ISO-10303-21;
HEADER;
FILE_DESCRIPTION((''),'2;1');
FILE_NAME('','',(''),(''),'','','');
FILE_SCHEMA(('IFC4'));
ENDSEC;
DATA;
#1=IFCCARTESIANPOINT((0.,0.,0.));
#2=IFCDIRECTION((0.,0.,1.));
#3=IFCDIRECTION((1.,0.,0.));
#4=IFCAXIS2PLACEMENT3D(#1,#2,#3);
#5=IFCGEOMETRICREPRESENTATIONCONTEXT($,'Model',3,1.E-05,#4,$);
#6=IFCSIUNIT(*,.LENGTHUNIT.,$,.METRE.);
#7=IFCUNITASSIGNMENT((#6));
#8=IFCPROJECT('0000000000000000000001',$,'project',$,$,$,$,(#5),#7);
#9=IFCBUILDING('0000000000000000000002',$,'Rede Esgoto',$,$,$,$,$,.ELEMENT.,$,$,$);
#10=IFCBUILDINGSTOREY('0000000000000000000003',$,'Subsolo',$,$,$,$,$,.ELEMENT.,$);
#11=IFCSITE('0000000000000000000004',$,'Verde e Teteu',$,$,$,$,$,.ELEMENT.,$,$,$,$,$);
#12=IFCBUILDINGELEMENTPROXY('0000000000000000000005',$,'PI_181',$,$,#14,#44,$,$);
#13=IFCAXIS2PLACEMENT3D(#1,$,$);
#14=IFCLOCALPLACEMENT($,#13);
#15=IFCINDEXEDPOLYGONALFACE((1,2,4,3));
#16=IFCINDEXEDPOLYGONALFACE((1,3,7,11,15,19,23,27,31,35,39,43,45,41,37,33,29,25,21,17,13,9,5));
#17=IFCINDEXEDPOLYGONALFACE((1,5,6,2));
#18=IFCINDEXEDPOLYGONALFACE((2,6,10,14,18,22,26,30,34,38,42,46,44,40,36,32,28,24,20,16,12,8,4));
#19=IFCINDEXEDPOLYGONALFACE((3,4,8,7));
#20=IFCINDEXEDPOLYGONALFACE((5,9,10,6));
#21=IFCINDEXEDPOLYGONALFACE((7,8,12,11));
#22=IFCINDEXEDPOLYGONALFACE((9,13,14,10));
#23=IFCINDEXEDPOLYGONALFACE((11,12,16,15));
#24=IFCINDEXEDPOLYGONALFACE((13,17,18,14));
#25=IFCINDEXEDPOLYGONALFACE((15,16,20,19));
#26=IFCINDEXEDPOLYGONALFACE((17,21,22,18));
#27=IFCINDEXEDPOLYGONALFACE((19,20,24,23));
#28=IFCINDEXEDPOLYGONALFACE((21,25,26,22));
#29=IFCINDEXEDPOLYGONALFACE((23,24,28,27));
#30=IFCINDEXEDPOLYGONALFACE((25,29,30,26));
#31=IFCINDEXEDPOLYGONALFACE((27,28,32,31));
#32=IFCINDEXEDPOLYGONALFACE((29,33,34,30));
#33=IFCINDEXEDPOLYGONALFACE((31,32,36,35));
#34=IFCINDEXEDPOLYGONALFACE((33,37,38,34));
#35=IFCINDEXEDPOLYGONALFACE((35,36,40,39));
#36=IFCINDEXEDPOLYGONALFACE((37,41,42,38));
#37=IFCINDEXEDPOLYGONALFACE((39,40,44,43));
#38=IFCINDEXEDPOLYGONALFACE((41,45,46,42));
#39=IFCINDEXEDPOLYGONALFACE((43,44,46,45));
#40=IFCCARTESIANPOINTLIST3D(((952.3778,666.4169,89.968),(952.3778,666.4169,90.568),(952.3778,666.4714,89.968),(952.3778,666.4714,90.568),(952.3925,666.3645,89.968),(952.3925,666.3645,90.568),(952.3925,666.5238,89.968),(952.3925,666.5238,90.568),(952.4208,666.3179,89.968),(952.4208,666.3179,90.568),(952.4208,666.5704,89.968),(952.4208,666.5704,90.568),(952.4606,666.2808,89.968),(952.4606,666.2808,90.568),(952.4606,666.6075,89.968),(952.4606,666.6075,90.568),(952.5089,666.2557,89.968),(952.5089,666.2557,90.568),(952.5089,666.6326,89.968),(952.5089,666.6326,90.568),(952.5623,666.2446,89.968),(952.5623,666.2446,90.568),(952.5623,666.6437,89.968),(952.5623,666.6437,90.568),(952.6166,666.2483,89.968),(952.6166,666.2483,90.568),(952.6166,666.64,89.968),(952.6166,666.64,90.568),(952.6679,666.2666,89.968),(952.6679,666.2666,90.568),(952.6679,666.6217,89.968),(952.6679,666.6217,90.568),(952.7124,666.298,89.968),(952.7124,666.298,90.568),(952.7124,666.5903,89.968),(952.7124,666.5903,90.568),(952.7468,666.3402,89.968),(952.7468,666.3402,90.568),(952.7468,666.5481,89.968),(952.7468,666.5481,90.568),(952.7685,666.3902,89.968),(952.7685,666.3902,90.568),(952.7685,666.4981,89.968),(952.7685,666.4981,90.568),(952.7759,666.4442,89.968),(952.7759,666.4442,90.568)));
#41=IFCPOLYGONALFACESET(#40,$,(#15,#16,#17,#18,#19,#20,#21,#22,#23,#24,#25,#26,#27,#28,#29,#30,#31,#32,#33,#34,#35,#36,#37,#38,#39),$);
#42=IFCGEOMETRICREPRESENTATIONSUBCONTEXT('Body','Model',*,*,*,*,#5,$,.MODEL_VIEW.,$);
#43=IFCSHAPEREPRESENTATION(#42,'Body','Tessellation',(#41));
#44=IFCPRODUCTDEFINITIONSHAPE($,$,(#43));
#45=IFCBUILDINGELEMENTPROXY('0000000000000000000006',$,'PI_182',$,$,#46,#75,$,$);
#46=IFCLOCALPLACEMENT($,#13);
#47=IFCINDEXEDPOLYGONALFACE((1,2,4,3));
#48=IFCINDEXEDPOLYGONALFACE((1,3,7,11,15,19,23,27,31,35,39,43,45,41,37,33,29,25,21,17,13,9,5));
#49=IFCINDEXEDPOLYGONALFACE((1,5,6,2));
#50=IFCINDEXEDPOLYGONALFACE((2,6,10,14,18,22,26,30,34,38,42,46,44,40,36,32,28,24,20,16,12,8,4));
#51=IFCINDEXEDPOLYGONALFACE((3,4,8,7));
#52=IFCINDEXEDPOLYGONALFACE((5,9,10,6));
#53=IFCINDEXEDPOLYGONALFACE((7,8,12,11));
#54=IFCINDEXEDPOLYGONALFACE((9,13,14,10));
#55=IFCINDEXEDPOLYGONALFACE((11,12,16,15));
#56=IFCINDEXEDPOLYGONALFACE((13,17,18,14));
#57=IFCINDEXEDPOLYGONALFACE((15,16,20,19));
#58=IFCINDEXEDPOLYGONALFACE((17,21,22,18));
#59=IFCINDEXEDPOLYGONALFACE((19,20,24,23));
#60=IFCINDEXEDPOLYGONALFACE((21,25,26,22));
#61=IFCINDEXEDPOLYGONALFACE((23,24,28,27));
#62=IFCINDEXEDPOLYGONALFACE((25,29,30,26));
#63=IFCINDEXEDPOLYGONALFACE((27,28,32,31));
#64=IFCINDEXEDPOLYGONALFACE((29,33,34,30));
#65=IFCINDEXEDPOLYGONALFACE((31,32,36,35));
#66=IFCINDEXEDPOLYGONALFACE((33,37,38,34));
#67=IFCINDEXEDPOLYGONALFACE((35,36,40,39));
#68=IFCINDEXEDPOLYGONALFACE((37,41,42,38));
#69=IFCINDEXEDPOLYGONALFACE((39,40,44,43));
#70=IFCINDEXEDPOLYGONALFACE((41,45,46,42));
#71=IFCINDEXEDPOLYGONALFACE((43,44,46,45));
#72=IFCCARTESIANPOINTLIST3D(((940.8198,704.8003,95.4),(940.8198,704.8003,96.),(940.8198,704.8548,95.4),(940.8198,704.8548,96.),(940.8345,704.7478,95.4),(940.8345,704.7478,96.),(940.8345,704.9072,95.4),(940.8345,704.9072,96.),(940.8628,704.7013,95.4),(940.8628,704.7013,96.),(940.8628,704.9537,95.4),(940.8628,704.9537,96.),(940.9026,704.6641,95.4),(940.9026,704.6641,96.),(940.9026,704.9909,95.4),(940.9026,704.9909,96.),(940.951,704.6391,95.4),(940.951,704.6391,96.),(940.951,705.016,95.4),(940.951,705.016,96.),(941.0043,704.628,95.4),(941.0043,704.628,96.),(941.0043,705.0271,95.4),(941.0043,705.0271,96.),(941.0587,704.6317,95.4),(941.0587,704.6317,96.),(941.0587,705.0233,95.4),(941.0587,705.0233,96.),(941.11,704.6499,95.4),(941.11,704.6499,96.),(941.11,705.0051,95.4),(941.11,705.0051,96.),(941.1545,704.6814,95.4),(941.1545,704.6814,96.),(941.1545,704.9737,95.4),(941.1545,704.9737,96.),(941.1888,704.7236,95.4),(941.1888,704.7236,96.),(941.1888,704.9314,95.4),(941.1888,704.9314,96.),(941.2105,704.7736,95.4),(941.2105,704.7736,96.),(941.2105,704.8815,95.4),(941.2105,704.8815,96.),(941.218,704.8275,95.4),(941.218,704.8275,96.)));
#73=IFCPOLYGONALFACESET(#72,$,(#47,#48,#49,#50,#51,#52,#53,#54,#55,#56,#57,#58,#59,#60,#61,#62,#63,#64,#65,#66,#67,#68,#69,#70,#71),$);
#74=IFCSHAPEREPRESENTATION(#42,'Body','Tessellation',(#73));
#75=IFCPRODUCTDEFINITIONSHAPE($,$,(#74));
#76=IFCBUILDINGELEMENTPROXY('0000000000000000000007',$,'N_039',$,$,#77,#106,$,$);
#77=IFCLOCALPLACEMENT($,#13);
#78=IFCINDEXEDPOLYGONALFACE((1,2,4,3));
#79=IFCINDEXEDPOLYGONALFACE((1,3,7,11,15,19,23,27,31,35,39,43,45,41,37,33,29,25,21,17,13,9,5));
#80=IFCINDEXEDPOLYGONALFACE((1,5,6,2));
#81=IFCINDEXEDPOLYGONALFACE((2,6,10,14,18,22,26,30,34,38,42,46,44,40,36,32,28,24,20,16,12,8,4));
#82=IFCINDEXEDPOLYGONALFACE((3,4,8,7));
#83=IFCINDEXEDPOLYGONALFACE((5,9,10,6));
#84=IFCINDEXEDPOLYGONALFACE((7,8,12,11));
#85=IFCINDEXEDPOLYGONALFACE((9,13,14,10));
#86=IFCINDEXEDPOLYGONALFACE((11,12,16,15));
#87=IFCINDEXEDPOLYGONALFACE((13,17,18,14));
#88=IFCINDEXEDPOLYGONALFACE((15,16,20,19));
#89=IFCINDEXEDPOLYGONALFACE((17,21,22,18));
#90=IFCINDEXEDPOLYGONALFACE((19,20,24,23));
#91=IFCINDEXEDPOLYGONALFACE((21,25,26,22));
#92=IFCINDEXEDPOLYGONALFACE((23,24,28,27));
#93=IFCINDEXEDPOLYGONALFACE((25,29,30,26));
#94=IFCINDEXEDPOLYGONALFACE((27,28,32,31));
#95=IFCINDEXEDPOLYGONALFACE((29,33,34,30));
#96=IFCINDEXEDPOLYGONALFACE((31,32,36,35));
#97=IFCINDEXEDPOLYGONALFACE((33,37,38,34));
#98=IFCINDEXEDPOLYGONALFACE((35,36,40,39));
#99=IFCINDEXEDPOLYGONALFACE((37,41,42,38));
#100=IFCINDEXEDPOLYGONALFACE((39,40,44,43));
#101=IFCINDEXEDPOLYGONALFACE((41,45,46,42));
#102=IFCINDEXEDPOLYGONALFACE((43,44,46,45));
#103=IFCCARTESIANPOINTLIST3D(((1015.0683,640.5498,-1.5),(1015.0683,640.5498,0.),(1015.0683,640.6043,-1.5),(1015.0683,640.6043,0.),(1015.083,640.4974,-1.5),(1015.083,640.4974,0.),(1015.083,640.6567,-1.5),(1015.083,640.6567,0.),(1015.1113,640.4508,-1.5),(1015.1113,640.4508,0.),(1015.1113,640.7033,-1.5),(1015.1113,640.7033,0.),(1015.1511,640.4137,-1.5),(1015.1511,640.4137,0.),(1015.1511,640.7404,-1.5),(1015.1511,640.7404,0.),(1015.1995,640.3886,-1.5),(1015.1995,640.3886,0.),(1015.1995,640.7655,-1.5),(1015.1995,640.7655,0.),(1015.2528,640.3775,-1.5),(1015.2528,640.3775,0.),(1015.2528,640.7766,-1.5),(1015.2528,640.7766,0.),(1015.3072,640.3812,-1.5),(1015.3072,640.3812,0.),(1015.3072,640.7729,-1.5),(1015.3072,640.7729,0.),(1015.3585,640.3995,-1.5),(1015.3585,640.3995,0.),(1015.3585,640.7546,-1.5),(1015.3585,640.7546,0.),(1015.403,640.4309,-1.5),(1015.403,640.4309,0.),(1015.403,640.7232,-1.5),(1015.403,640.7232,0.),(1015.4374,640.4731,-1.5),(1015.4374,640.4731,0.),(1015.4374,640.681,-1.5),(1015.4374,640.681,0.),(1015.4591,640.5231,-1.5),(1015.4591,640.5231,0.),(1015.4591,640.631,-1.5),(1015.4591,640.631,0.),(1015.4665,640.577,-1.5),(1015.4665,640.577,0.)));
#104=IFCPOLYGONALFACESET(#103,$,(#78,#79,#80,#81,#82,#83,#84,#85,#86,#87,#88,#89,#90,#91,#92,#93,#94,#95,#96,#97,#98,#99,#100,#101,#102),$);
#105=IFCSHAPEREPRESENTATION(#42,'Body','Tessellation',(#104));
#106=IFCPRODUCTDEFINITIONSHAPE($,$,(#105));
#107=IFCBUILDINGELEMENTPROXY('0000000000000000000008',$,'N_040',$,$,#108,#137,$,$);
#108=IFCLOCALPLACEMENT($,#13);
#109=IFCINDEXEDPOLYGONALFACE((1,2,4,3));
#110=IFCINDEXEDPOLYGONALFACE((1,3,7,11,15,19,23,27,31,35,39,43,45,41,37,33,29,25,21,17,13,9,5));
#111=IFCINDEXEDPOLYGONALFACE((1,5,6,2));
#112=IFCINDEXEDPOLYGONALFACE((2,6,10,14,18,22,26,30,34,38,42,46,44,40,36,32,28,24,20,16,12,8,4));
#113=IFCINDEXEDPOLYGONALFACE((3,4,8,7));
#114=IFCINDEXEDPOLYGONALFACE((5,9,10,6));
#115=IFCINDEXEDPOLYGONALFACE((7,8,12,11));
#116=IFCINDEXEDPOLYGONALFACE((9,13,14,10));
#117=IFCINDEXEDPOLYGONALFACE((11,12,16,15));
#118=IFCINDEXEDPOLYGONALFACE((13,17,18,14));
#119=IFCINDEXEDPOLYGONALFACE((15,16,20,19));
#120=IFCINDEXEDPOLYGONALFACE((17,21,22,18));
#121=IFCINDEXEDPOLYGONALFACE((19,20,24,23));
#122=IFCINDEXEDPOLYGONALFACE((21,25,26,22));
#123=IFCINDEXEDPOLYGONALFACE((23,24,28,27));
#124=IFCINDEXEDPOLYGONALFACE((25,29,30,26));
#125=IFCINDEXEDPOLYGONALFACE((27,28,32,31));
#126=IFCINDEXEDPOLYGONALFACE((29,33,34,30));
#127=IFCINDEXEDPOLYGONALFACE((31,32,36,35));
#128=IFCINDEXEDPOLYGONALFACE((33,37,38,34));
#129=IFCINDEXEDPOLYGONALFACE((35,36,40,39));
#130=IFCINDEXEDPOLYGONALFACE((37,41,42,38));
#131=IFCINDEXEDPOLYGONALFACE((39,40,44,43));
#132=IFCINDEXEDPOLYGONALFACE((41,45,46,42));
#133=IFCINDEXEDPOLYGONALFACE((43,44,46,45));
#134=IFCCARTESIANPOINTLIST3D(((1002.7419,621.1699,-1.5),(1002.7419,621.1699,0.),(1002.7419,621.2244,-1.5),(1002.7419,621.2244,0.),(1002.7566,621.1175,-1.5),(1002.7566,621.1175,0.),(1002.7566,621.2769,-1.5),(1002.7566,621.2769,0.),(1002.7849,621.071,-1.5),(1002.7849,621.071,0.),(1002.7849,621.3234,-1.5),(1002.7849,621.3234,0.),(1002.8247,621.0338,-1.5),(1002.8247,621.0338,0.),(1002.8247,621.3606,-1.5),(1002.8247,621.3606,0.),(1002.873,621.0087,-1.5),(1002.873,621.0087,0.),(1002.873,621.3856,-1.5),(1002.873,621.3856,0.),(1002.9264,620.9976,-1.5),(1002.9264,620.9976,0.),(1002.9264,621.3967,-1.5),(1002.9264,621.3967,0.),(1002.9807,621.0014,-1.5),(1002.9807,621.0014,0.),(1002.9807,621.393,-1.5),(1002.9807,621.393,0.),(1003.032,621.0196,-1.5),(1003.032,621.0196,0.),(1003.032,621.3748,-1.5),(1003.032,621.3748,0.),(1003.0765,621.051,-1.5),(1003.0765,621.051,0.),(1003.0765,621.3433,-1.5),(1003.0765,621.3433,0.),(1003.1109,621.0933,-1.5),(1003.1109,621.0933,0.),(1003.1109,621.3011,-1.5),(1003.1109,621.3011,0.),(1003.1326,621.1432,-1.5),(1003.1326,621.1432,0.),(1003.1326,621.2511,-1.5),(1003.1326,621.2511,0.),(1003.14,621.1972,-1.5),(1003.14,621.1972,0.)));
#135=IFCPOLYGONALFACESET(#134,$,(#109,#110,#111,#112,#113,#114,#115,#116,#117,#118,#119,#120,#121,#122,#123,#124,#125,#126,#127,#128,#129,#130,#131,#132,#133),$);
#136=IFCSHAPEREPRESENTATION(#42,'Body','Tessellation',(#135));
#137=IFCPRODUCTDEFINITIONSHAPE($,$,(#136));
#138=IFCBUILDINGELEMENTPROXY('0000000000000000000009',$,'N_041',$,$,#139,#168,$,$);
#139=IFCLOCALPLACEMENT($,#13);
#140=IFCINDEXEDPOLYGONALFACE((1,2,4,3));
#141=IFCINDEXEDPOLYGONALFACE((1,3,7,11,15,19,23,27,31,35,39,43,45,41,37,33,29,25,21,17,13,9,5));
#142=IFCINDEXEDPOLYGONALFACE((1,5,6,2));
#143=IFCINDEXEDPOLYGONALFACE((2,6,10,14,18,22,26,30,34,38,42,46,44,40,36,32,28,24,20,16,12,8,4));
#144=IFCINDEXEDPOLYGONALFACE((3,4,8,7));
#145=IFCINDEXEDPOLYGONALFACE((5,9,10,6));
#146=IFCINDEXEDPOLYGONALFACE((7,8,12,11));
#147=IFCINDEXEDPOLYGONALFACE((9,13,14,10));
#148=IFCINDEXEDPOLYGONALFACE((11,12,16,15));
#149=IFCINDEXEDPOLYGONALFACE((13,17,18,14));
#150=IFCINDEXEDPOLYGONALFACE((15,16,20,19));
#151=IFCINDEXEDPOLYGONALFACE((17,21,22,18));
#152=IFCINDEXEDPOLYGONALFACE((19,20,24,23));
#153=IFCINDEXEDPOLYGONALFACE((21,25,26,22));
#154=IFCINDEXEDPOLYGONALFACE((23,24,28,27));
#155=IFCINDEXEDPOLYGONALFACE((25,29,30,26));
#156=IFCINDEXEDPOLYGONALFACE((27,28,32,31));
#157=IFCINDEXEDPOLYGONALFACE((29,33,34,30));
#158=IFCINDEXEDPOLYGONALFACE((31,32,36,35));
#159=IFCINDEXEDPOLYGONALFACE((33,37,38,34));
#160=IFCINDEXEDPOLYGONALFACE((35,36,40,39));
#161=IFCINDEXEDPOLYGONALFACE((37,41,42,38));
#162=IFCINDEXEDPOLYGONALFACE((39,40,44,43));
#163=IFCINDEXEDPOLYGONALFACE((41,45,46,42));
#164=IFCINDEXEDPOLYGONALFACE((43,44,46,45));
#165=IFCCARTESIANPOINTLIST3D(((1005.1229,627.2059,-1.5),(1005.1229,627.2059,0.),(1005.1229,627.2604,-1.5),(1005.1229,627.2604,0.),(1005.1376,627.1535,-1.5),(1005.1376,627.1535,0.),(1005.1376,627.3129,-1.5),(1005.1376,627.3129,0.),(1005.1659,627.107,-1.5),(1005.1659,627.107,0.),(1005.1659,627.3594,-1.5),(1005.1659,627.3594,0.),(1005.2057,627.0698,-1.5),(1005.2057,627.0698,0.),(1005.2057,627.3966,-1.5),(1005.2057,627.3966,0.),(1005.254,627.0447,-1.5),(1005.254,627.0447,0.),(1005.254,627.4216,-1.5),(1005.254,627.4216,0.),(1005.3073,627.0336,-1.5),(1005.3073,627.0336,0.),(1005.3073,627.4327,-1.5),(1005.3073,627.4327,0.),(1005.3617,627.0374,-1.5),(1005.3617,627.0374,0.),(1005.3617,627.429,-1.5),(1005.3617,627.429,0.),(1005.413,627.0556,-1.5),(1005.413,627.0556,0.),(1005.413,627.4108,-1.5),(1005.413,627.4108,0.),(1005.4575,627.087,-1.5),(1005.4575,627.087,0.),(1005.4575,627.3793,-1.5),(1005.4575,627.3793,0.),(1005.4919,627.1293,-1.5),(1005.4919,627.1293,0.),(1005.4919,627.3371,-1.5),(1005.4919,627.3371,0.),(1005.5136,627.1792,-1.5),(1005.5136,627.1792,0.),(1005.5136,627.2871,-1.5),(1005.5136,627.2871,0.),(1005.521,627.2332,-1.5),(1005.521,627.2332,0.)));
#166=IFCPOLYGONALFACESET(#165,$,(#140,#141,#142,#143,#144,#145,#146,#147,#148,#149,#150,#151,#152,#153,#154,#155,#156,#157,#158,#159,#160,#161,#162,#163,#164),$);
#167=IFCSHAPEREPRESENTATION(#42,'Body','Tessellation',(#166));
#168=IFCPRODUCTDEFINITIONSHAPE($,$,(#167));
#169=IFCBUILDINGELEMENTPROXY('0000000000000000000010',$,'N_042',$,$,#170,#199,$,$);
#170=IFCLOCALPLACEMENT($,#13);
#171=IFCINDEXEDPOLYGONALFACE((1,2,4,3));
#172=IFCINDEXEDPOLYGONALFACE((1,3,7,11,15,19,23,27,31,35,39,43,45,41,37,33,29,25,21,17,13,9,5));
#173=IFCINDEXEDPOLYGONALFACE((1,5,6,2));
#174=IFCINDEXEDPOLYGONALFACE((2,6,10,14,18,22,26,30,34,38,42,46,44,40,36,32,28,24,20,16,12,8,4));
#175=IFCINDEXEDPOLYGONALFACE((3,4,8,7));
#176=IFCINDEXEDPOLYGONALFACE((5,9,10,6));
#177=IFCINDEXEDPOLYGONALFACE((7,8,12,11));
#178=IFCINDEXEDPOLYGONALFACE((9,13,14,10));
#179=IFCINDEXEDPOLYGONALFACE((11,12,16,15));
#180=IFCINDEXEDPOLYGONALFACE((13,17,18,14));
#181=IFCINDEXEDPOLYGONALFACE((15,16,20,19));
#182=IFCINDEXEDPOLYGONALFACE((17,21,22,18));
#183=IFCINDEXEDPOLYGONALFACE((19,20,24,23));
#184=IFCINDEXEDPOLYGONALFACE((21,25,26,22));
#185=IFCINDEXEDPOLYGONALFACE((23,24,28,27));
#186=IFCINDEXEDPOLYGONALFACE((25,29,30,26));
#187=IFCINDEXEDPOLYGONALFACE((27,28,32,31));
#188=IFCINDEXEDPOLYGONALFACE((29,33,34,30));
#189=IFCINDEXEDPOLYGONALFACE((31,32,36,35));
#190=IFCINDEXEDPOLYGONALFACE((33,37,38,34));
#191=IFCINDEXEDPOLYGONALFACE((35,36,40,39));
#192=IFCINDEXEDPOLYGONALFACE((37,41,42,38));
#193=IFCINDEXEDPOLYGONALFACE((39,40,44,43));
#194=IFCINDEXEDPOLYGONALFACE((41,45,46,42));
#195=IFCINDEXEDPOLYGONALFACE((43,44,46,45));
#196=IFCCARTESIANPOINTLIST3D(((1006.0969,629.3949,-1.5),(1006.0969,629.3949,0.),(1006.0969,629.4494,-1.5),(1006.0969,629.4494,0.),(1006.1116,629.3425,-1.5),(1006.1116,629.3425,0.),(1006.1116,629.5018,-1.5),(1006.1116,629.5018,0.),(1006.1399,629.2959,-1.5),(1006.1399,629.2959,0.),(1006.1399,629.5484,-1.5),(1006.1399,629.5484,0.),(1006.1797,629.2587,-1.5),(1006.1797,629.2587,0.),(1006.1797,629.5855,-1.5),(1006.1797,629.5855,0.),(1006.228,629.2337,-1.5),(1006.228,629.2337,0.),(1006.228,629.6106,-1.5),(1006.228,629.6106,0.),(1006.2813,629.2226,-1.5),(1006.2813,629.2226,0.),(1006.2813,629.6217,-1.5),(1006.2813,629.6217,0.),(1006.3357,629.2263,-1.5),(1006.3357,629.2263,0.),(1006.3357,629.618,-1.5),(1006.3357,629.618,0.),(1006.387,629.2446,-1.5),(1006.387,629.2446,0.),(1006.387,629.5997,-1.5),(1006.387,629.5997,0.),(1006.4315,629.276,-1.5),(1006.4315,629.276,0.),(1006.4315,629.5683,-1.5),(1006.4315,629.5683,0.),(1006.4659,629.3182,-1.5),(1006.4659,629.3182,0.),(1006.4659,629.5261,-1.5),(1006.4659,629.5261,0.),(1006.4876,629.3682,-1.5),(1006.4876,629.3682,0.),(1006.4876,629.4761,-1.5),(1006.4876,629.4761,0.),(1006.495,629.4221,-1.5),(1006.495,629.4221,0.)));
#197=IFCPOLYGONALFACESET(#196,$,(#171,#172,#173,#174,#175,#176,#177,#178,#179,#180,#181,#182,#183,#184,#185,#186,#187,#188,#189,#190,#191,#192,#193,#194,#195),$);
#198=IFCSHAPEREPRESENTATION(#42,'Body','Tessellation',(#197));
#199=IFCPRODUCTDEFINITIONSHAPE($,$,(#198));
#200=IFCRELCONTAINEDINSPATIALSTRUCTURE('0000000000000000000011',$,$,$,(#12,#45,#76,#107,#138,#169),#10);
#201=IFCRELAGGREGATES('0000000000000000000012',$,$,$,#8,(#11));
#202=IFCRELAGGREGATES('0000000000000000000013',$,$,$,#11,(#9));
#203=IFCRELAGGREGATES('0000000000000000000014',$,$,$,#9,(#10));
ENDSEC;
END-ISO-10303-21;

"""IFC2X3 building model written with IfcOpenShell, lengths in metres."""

from ifc_helpers import new_model, si_unit, frame, origin_with_axes, origin_2d, place, context, subcontext, project, spatial, circle, extrude, element, save


model = new_model("IFC2X3")

# Units and contexts
model_context = context("Model", 3, precision=1e-05, world=origin_with_axes())
body_context = subcontext(model_context, "Body", "Model", "MODEL_VIEW")
ifc_project = project(units=[si_unit("LENGTHUNIT", "METRE")], contexts=[model_context])

# Site, building, storey
site = spatial("IfcSite", under=ifc_project, Name="Verde e Teteu", CompositionType="ELEMENT")
building = spatial("IfcBuilding", under=site, Name="Rede Esgoto", CompositionType="ELEMENT")
storey = spatial("IfcBuildingStorey", under=building, Name="Subsolo", CompositionType="ELEMENT")

# Building element proxies
for number, where, z_axis, x_axis, name in (
    (1, (952.5759, 666.4442, 89.968), (0.0, 0.0, 1.0), (1.0, 0.0, 0.0), "PI_181"),
    (2, (941.018, 704.8275, 95.4), (0.0, 0.0, 1.0), (1.0, 0.0, 0.0), "PI_182"),
):
    element("IfcBuildingElementProxy", number, at=place(None, frame(where, z_axis=z_axis, x_axis=x_axis)), inside=storey, Name=name, context=body_context, shape_type="SweptSolid", body=[
        extrude(circle(Radius=0.2, at=origin_2d()), origin_with_axes(), (0.0, 0.0, 1.0), 0.6),
    ])
for number, where, z_axis, x_axis, name in (
    (3, (1015.2665, 640.577, -1.5), (0.0, 0.0, 1.0), (1.0, 0.0, 0.0), "N_039"),
    (4, (1002.94, 621.1972, -1.5), (0.0, 0.0, 1.0), (1.0, 0.0, 0.0), "N_040"),
    (5, (1005.321, 627.2332, -1.5), (0.0, 0.0, 1.0), (1.0, 0.0, 0.0), "N_041"),
    (6, (1006.295, 629.4221, -1.5), (0.0, 0.0, 1.0), (1.0, 0.0, 0.0), "N_042"),
):
    element("IfcBuildingElementProxy", number, at=place(None, frame(where, z_axis=z_axis, x_axis=x_axis)), inside=storey, Name=name, context=body_context, shape_type="SweptSolid", body=[
        extrude(circle(Radius=0.2, at=origin_2d()), origin_with_axes(), (0.0, 0.0, 1.0), 1.5),
    ])

save(model, "model.ifc")
